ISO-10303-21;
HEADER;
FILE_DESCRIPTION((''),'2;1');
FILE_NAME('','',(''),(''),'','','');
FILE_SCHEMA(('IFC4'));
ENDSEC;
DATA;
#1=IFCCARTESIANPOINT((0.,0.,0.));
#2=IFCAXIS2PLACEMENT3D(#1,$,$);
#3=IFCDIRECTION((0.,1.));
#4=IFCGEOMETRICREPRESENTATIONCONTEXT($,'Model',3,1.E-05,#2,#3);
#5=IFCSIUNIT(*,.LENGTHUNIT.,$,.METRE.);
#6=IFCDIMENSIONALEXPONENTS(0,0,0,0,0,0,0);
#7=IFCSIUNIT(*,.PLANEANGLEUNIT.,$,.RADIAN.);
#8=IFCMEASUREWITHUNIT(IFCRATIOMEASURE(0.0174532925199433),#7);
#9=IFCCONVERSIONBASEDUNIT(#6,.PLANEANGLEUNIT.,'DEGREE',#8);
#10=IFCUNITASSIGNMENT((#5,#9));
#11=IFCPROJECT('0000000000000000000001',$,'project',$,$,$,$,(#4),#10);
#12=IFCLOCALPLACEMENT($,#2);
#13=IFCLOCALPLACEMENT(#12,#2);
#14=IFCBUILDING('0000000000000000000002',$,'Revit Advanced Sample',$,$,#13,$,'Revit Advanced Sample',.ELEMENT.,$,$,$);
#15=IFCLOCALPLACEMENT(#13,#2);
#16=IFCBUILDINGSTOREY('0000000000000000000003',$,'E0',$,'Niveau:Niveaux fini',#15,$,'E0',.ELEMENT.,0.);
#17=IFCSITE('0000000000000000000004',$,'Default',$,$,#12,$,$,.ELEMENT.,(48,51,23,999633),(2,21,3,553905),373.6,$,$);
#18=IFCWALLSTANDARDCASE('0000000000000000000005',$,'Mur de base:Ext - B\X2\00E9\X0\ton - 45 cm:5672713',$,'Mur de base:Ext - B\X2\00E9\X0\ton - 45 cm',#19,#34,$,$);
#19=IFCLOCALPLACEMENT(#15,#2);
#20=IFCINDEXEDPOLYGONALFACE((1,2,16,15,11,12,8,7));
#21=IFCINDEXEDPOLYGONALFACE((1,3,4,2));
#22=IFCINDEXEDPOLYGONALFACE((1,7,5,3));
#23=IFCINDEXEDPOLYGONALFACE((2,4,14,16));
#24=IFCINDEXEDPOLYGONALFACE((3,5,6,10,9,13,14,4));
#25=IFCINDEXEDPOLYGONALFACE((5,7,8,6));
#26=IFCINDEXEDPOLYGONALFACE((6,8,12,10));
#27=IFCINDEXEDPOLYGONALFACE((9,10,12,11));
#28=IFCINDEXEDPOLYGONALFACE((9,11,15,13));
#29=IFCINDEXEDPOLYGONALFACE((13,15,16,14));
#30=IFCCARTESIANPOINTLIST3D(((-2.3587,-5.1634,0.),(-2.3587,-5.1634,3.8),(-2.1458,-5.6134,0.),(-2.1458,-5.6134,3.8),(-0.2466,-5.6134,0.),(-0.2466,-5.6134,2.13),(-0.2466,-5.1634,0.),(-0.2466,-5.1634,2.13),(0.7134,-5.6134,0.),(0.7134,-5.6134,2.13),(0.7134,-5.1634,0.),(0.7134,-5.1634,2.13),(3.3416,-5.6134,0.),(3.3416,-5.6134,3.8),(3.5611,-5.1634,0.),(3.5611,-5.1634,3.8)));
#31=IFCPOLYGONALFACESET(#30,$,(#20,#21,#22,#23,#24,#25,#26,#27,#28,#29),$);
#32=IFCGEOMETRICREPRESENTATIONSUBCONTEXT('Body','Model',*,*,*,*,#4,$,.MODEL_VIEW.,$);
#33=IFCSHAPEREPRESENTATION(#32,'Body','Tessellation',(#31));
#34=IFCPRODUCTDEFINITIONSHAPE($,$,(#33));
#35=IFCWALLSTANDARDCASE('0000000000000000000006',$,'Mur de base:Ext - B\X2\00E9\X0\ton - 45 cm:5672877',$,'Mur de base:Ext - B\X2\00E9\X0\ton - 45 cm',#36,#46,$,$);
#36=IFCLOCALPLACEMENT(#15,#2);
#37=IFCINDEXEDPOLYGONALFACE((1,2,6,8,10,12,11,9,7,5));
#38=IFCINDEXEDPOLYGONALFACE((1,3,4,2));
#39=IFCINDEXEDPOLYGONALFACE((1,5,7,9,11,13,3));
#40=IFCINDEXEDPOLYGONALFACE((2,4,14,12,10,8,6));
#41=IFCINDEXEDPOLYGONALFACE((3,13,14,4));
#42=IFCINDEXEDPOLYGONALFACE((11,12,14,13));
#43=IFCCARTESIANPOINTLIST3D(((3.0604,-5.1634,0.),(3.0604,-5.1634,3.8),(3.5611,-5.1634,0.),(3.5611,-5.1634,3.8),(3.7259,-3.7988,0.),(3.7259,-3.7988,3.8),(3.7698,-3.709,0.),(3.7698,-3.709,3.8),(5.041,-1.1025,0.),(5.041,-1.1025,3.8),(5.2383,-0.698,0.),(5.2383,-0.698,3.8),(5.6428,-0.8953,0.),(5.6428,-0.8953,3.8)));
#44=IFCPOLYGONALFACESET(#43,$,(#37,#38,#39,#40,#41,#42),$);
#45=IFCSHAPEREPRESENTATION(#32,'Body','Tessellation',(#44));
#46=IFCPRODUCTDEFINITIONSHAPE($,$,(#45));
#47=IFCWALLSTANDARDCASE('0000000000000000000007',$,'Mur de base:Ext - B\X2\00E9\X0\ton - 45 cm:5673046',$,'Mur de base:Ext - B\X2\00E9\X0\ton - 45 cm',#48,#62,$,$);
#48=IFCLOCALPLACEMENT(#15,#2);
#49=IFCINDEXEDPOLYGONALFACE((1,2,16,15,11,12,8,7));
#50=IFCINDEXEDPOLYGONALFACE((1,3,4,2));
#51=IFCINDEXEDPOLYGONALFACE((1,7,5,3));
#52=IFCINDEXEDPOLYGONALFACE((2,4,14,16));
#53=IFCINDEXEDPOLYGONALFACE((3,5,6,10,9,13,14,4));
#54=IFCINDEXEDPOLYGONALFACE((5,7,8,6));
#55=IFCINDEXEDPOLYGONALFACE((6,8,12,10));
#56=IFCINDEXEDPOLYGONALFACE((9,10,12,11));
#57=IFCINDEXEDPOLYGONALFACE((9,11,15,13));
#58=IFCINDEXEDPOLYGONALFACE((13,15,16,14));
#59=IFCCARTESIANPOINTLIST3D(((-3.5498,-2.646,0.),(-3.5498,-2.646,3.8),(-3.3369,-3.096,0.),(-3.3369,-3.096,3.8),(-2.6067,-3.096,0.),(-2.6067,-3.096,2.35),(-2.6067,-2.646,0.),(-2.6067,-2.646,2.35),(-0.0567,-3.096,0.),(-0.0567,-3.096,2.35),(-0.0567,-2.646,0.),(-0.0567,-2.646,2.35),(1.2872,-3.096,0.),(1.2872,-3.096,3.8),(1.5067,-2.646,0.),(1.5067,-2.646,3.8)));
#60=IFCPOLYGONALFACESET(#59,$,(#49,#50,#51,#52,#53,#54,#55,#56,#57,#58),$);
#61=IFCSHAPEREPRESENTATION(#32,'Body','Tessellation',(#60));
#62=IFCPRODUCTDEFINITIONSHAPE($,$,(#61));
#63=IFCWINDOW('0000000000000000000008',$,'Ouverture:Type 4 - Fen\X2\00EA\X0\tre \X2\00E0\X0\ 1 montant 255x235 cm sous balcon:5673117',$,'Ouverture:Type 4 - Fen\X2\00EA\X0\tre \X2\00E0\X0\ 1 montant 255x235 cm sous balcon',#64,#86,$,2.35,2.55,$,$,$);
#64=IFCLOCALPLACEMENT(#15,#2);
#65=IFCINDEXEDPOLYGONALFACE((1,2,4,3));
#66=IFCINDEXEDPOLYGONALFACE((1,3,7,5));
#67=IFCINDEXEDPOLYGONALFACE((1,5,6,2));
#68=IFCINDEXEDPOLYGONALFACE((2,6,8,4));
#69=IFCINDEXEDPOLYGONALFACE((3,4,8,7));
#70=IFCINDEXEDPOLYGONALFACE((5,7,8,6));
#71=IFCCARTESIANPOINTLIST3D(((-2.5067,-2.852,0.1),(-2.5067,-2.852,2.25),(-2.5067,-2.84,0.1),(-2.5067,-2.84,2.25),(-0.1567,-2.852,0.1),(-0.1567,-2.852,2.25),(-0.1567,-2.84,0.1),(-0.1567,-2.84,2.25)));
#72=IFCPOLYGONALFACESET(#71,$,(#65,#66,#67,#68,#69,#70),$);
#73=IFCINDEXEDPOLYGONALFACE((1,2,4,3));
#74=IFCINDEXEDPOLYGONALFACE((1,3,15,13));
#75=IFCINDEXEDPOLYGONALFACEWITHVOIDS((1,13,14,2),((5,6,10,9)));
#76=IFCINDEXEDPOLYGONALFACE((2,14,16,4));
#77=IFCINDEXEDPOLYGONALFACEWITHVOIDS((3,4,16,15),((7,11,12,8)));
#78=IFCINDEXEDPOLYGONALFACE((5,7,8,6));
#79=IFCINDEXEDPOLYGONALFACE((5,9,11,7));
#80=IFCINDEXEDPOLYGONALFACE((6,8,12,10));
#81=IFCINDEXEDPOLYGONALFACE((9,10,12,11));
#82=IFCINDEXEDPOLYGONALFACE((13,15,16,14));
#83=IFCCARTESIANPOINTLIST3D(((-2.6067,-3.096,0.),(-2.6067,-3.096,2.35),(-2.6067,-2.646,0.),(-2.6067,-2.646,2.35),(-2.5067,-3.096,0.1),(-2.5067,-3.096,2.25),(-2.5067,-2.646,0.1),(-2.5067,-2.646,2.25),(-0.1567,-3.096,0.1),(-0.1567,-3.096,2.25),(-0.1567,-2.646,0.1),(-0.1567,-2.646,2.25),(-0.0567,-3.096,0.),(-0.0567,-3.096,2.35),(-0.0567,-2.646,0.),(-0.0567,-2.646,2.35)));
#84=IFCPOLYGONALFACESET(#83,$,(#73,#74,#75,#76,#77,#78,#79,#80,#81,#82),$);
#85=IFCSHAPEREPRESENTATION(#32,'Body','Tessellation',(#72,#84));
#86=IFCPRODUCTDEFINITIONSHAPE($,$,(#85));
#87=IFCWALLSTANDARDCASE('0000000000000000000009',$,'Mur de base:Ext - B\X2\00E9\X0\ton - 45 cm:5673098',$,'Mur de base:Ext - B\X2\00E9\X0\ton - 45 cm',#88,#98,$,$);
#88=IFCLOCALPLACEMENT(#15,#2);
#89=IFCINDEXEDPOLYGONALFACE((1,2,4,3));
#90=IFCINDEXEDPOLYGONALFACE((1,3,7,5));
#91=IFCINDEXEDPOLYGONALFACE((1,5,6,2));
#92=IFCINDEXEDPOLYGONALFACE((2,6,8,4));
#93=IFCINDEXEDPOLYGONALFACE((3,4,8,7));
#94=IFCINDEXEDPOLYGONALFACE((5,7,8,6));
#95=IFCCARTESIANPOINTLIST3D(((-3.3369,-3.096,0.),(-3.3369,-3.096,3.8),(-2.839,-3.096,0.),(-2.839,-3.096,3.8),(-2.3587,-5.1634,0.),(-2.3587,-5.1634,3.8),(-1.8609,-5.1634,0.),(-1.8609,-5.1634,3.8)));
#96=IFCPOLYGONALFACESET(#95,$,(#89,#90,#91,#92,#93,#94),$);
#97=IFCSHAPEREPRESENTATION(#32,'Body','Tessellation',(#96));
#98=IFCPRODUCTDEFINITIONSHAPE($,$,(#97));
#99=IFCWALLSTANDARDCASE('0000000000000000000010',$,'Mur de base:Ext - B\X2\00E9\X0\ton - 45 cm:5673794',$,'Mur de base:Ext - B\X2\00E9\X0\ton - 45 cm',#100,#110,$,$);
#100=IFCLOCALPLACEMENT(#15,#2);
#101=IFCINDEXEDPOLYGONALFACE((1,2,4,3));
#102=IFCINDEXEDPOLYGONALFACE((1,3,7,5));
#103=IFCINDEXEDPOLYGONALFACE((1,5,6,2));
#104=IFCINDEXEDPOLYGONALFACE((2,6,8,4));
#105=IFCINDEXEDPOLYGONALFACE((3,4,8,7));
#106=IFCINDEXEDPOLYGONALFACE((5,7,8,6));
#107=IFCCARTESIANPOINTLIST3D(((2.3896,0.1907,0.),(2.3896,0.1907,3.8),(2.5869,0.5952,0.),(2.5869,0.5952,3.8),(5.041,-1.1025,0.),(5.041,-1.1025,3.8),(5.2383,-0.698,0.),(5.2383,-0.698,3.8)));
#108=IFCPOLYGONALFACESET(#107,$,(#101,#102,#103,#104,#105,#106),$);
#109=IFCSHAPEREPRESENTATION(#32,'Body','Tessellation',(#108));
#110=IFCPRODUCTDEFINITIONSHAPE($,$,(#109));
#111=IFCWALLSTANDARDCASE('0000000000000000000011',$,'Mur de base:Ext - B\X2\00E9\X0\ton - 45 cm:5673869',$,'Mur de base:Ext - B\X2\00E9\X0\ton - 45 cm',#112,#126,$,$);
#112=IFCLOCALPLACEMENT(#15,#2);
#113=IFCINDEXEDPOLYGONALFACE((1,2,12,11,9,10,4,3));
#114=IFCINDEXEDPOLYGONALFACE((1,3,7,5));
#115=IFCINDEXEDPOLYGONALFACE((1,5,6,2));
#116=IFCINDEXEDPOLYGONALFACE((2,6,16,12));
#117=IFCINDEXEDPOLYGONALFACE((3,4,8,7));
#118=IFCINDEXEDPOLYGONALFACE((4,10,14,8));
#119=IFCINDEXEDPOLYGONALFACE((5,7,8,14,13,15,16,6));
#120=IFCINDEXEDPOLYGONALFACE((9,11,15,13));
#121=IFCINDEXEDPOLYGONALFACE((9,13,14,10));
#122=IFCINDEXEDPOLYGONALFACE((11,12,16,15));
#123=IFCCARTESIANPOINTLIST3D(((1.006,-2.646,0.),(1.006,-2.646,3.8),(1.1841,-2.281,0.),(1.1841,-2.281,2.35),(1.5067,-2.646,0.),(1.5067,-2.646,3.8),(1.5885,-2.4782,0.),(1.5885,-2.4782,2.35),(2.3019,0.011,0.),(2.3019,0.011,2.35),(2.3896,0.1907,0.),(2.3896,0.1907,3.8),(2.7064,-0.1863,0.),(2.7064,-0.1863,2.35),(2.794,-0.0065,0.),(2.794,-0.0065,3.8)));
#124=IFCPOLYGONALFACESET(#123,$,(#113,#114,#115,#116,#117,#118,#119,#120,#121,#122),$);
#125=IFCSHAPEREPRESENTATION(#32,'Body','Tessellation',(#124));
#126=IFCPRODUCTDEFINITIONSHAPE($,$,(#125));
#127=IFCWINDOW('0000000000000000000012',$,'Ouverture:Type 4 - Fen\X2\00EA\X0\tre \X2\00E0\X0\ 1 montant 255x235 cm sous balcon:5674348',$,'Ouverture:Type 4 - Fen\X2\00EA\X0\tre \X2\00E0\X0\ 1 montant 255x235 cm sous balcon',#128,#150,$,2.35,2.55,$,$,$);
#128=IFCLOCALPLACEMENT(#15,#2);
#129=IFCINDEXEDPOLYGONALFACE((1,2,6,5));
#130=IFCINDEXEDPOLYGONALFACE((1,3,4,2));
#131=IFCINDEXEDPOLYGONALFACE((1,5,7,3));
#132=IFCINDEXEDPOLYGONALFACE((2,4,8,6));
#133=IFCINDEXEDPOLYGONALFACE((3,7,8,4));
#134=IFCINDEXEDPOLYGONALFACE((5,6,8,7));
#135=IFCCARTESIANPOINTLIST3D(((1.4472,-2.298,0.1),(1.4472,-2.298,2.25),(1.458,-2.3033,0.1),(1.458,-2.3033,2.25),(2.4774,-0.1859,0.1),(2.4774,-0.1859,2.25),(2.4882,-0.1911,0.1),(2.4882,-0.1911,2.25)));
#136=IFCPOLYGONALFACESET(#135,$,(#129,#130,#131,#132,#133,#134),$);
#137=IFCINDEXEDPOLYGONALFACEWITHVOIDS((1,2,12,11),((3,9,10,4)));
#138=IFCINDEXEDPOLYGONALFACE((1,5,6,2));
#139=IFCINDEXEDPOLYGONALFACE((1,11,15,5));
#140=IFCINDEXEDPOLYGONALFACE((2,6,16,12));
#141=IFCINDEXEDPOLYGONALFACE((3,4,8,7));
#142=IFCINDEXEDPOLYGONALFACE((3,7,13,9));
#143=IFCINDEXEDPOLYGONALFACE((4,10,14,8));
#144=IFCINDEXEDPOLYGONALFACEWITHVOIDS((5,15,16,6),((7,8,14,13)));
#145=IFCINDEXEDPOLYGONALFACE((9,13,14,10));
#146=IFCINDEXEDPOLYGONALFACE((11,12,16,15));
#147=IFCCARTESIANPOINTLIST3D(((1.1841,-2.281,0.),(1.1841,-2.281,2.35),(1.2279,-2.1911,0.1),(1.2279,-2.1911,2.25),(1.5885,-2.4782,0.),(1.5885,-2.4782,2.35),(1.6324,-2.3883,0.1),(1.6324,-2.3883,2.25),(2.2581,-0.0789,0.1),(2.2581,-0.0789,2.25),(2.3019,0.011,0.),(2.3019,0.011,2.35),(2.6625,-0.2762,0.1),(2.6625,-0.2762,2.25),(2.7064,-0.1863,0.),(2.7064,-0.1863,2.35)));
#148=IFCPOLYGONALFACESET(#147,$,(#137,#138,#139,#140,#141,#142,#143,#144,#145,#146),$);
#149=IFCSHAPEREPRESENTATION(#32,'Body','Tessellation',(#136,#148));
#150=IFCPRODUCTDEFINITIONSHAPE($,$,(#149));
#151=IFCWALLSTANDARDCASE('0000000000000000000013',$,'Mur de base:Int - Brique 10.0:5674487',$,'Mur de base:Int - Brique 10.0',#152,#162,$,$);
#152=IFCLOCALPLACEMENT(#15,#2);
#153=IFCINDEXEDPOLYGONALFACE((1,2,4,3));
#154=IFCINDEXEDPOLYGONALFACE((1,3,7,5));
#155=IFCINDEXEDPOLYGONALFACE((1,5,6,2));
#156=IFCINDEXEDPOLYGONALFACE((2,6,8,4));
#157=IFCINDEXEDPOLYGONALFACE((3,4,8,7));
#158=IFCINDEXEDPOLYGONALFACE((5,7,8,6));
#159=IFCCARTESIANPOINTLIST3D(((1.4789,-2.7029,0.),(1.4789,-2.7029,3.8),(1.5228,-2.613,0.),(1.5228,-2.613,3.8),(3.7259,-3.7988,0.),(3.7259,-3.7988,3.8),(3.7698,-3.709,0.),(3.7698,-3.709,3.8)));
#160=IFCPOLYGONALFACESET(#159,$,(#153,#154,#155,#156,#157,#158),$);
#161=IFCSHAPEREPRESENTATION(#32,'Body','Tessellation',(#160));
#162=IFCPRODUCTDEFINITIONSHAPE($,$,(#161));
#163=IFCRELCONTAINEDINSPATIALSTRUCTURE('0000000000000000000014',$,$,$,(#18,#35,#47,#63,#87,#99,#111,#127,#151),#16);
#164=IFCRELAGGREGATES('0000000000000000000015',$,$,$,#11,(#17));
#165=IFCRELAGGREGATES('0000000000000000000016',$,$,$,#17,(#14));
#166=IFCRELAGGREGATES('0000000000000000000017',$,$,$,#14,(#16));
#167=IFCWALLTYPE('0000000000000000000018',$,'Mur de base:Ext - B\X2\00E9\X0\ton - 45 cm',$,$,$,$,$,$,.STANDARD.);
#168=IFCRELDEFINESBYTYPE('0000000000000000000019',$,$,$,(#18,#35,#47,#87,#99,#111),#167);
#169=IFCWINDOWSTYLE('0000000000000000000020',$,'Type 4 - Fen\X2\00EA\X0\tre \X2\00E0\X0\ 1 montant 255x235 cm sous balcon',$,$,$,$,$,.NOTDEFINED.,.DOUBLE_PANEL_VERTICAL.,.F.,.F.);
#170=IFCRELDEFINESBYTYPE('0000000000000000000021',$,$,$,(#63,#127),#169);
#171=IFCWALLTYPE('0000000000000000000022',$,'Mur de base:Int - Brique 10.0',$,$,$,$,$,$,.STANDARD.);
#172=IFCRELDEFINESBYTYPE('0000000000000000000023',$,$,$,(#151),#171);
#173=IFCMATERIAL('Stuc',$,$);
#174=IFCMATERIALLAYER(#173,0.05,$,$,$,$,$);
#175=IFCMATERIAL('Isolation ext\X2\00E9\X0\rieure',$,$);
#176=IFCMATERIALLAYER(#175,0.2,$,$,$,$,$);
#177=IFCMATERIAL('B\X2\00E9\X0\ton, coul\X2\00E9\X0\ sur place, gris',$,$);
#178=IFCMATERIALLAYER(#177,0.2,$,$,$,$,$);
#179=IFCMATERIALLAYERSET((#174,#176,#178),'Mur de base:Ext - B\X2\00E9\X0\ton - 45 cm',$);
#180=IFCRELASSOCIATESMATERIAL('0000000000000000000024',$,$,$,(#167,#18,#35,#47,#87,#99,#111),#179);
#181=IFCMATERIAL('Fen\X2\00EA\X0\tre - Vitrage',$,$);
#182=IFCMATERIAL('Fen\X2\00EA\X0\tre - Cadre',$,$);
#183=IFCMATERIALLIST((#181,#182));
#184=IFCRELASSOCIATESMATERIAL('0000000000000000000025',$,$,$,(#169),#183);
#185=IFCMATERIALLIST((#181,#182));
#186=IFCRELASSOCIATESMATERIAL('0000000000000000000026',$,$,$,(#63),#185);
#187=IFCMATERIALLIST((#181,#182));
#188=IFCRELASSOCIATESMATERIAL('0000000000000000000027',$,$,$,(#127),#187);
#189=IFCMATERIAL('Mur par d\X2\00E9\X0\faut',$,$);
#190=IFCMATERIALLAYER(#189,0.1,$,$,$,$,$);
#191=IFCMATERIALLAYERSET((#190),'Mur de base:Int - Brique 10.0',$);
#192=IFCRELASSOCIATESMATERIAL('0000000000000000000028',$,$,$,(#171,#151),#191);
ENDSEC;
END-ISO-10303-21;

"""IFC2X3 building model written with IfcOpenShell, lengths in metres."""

from ifc_helpers import new_model, entity, si_unit, converted_unit, direction, frame, frame_2d, origin, place, context, subcontext, project, spatial, polyline, rectangle, outline, extrude, source, transform, mapped, material, material_list, layer, layer_set, layer_usage, type_object, type_shapes, element, fill, save


model = new_model("IFC2X3")

# Units and contexts
model_context = context("Model", 3, precision=1e-05, world=origin(), true_north=direction((0.0, 1.0)))
body_context = subcontext(model_context, "Body", "Model", "MODEL_VIEW")
ifc_project = project(units=[si_unit("LENGTHUNIT", "METRE"), converted_unit("PLANEANGLEUNIT", "DEGREE", entity("IfcRatioMeasure", 0.0174532925199433), si_unit("PLANEANGLEUNIT", "RADIAN"), dimensions=[0, 0, 0, 0, 0, 0, 0])], contexts=[model_context])

# Site, building, storey
site_placement = place(None, origin())
site = spatial("IfcSite", under=ifc_project, at=site_placement, Name="Default", CompositionType="ELEMENT", RefLatitude=(48, 51, 23, 999633), RefLongitude=(2, 21, 3, 553905), RefElevation=373.6)
building_placement = place(site_placement, origin())
building = spatial("IfcBuilding", under=site, at=building_placement, Name="Revit Advanced Sample", LongName="Revit Advanced Sample", CompositionType="ELEMENT")
storey_placement = place(building_placement, origin())
storey = spatial("IfcBuildingStorey", under=building, at=storey_placement, Name="E0", ObjectType="Niveau:Niveaux fini", LongName="E0", CompositionType="ELEMENT", Elevation=0.0)

# Wall, opening
ifc_material_1 = material(Name="Stuc")
ifc_layer_1 = layer(ifc_material_1, 0.05)
ifc_material_2 = material(Name="Isolation extérieure")
ifc_layer_2 = layer(ifc_material_2, 0.2)
ifc_material_3 = material(Name="Béton, coulé sur place, gris")
ifc_layer_3 = layer(ifc_material_3, 0.2)
ifc_layer_set_1 = layer_set([ifc_layer_1, ifc_layer_2, ifc_layer_3], Name="Mur de base:Ext - Béton - 45 cm")
ifc_layer_usage_1 = layer_usage(ifc_layer_set_1, "AXIS2", "POSITIVE", -0.225)
wall_type_1 = type_object("IfcWallType", Name="Mur de base:Ext - Béton - 45 cm", PredefinedType="STANDARD", material=ifc_layer_set_1)
wall_1_placement = place(storey_placement, frame((-2.3587, -5.3884, 0.0)))
wall_1 = element("IfcWallStandardCase", 1, at=wall_1_placement, inside=storey, type_object=wall_type_1, material=ifc_layer_usage_1, Name="Mur de base:Ext - Béton - 45 cm:5672713", ObjectType="Mur de base:Ext - Béton - 45 cm", context=body_context, shape_type="SweptSolid", body=[
    extrude(outline(polyline([(0.2129, -0.225), (5.7003, -0.225), (5.9198, 0.225), (5.4191, 0.225), (0.4978, 0.225), (0.0, 0.225), (0.2129, -0.225)])), origin(), (0.0, 0.0, 1.0), 3.8),
])
opening_1_placement = place(wall_1_placement, frame((3.0721, 0.225, 0.0)))
element("IfcOpeningElement", 2, at=opening_1_placement, cuts=wall_1, ObjectType="Opening", context=body_context, shape_type="SweptSolid", body=[
    extrude(rectangle(XDim=2.13, YDim=0.96, at=frame_2d((1.065, 0.48), x_axis=(1.0, 0.0))), frame((0.0, 0.0, 0.0), z_axis=(0.0, -1.0, 0.0), x_axis=(0.0, 0.0, 1.0)), (0.0, 0.0, 1.0), 0.45),
])

# Wall
ifc_layer_usage_2 = layer_usage(ifc_layer_set_1, "AXIS2", "POSITIVE", -0.225)
wall_2_placement = place(storey_placement, frame((3.2626, -5.262, 0.0), z_axis=(0.0, 0.0, 1.0), x_axis=(0.438371, 0.898794, 0.0)))
element("IfcWallStandardCase", 3, at=wall_2_placement, inside=storey, type_object=wall_type_1, material=ifc_layer_usage_2, Name="Mur de base:Ext - Béton - 45 cm:5672877", ObjectType="Mur de base:Ext - Béton - 45 cm", context=body_context, shape_type="SweptSolid", body=[
    extrude(outline(polyline([(4.9682, -0.225), (4.9682, 0.225), (4.5182, 0.225), (1.6182, 0.225), (1.5182, 0.225), (0.0, 0.225), (0.2195, -0.225), (4.9682, -0.225)])), origin(), (0.0, 0.0, 1.0), 3.8),
])

# Wall, opening, window
ifc_layer_usage_3 = layer_usage(ifc_layer_set_1, "AXIS2", "POSITIVE", -0.225)
wall_3_placement = place(storey_placement, frame((1.5067, -2.871, 0.0), z_axis=(0.0, 0.0, 1.0), x_axis=(-1.0, 0.0, 0.0)))
wall_3 = element("IfcWallStandardCase", 4, at=wall_3_placement, inside=storey, type_object=wall_type_1, material=ifc_layer_usage_3, Name="Mur de base:Ext - Béton - 45 cm:5673046", ObjectType="Mur de base:Ext - Béton - 45 cm", context=body_context, shape_type="SweptSolid", body=[
    extrude(outline(polyline([(0.0, -0.225), (0.5007, -0.225), (5.0565, -0.225), (4.8435, 0.225), (4.3457, 0.225), (0.2195, 0.225), (0.0, -0.225)])), origin(), (0.0, 0.0, 1.0), 3.8),
])
opening_2_placement = place(wall_3_placement, frame((4.1133, 0.225, 0.0)))
opening_2 = element("IfcOpeningElement", 5, at=opening_2_placement, cuts=wall_3, ObjectType="Opening", context=body_context, shape_type="SweptSolid", body=[
    extrude(rectangle(XDim=2.35, YDim=2.55, at=frame_2d((1.175, 1.275), x_axis=(-1.0, 0.0))), frame((0.0, 0.0, 0.0), z_axis=(0.0, -1.0, 0.0), x_axis=(0.0, 0.0, 1.0)), (0.0, 0.0, 1.0), 0.45),
])
ifc_material_4 = material(Name="Fenêtre - Vitrage")
ifc_material_5 = material(Name="Fenêtre - Cadre")
ifc_material_list_1 = material_list([ifc_material_4, ifc_material_5])
ifc_material_list_2 = material_list([ifc_material_4, ifc_material_5])
window_style = type_object("IfcWindowStyle", Name="Type 4 - Fenêtre à 1 montant 255x235 cm sous balcon", ConstructionType="NOTDEFINED", OperationType="DOUBLE_PANEL_VERTICAL", ParameterTakesPrecedence=False, Sizeable=False, material=ifc_material_list_2)
shared_shape = source(origin(), body_context, "Body", "SweptSolid", [
    extrude(rectangle(XDim=0.012, YDim=2.35, at=frame_2d((0.0, 0.0), x_axis=(1.0, 0.0))), frame((1.275, 0.2, 0.1), z_axis=(0.0, 0.0, 1.0), x_axis=(0.0, -1.0, 0.0)), (0.0, 0.0, 1.0), 2.15),
    extrude(outline(polyline([(-1.275, -1.175), (1.275, -1.175), (1.275, 1.175), (-1.275, 1.175), (-1.275, -1.175)]), holes=[polyline([(-1.175, -1.075), (-1.175, 1.075), (1.175, 1.075), (1.175, -1.075), (-1.175, -1.075)])]), frame((1.275, 0.0, 1.175), z_axis=(0.0, 1.0, 0.0), x_axis=(1.0, 0.0, 0.0)), (0.0, 0.0, 1.0), 0.45),
])
type_shapes(window_style, [shared_shape])
window_1_placement = place(opening_2_placement, frame((-2.55, -0.45, 0.0)))
window_1 = element("IfcWindow", 6, at=window_1_placement, inside=storey, type_object=window_style, material=ifc_material_list_1, Name="Ouverture:Type 4 - Fenêtre à 1 montant 255x235 cm sous balcon:5673117", ObjectType="Ouverture:Type 4 - Fenêtre à 1 montant 255x235 cm sous balcon", OverallHeight=2.35, OverallWidth=2.55, context=body_context, shape_type="MappedRepresentation", body=[
    mapped(shared_shape, transform((0.0, 0.0, 0.0), scale=1.0)),
])
fill(opening_2, window_1)

# Walls
ifc_layer_usage_4 = layer_usage(ifc_layer_set_1, "AXIS2", "POSITIVE", -0.225)
wall_4_placement = place(storey_placement, frame((-3.1335, -2.9998, 0.0), z_axis=(0.0, 0.0, 1.0), x_axis=(0.427693, -0.903924, 0.0)))
element("IfcWallStandardCase", 7, at=wall_4_placement, inside=storey, type_object=wall_type_1, material=ifc_layer_usage_4, Name="Mur de base:Ext - Béton - 45 cm:5673098", ObjectType="Mur de base:Ext - Béton - 45 cm", context=body_context, shape_type="SweptSolid", body=[
    extrude(outline(polyline([(2.2871, -0.225), (2.5, 0.225), (0.2129, 0.225), (0.0, -0.225), (2.2871, -0.225)])), origin(), (0.0, 0.0, 1.0), 3.8),
])
ifc_layer_usage_5 = layer_usage(ifc_layer_set_1, "AXIS2", "POSITIVE", -0.225)
wall_5_placement = place(storey_placement, frame((5.1397, -0.9002, 0.0), z_axis=(0.0, 0.0, 1.0), x_axis=(-0.898794, 0.438371, 0.0)))
element("IfcWallStandardCase", 8, at=wall_5_placement, inside=storey, type_object=wall_type_1, material=ifc_layer_usage_5, Name="Mur de base:Ext - Béton - 45 cm:5673794", ObjectType="Mur de base:Ext - Béton - 45 cm", context=body_context, shape_type="SweptSolid", body=[
    extrude(rectangle(XDim=2.95, YDim=0.45, at=frame_2d((1.475, 0.0), x_axis=(-1.0, 0.0))), origin(), (0.0, 0.0, 1.0), 3.8),
])

# Wall, opening, window
ifc_layer_usage_6 = layer_usage(ifc_layer_set_1, "AXIS2", "POSITIVE", -0.225)
wall_6_placement = place(storey_placement, frame((2.5918, 0.0921, 0.0), z_axis=(0.0, 0.0, 1.0), x_axis=(-0.438371, -0.898794, 0.0)))
wall_6 = element("IfcWallStandardCase", 9, at=wall_6_placement, inside=storey, type_object=wall_type_1, material=ifc_layer_usage_6, Name="Mur de base:Ext - Béton - 45 cm:5673869", ObjectType="Mur de base:Ext - Béton - 45 cm", context=body_context, shape_type="SweptSolid", body=[
    extrude(outline(polyline([(0.0, -0.225), (3.1562, -0.225), (2.9367, 0.225), (2.9, 0.225), (0.0, 0.225), (0.0, -0.225)])), origin(), (0.0, 0.0, 1.0), 3.8),
])
opening_3_placement = place(wall_6_placement, frame((0.2, -0.225, 0.0)))
opening_3 = element("IfcOpeningElement", 10, at=opening_3_placement, cuts=wall_6, ObjectType="Opening", context=body_context, shape_type="SweptSolid", body=[
    extrude(rectangle(XDim=2.35, YDim=2.55, at=frame_2d((1.175, 1.275), x_axis=(-1.0, 0.0))), frame((0.0, 0.0, 0.0), z_axis=(0.0, 1.0, 0.0), x_axis=(0.0, 0.0, 1.0)), (0.0, 0.0, 1.0), 0.45),
])
ifc_material_list_3 = material_list([ifc_material_4, ifc_material_5])
window_2_placement = place(opening_3_placement, frame((2.55, 0.45, 0.0), z_axis=(0.0, 0.0, 1.0), x_axis=(-1.0, 0.0, 0.0)))
window_2 = element("IfcWindow", 11, at=window_2_placement, inside=storey, type_object=window_style, material=ifc_material_list_3, Name="Ouverture:Type 4 - Fenêtre à 1 montant 255x235 cm sous balcon:5674348", ObjectType="Ouverture:Type 4 - Fenêtre à 1 montant 255x235 cm sous balcon", OverallHeight=2.35, OverallWidth=2.55, context=body_context, shape_type="MappedRepresentation", body=[
    mapped(shared_shape, transform((0.0, 0.0, 0.0), scale=1.0)),
])
fill(opening_3, window_2)

# Wall
ifc_material_6 = material(Name="Mur par défaut")
ifc_layer_4 = layer(ifc_material_6, 0.1)
ifc_layer_set_2 = layer_set([ifc_layer_4], Name="Mur de base:Int - Brique 10.0")
ifc_layer_usage_7 = layer_usage(ifc_layer_set_2, "AXIS2", "NEGATIVE", 0.05)
wall_type_2 = type_object("IfcWallType", Name="Mur de base:Int - Brique 10.0", PredefinedType="STANDARD", material=ifc_layer_set_2)
wall_7_placement = place(storey_placement, frame((1.5008, -2.658, 0.0), z_axis=(0.0, 0.0, 1.0), x_axis=(0.898794, -0.438371, 0.0)))
element("IfcWallStandardCase", 12, at=wall_7_placement, inside=storey, type_object=wall_type_2, material=ifc_layer_usage_7, Name="Mur de base:Int - Brique 10.0:5674487", ObjectType="Mur de base:Int - Brique 10.0", context=body_context, shape_type="SweptSolid", body=[
    extrude(rectangle(XDim=2.5, YDim=0.1, at=frame_2d((1.25, 0.0), x_axis=(-1.0, 0.0))), origin(), (0.0, 0.0, 1.0), 3.8),
])

save(model, "model.ifc")
